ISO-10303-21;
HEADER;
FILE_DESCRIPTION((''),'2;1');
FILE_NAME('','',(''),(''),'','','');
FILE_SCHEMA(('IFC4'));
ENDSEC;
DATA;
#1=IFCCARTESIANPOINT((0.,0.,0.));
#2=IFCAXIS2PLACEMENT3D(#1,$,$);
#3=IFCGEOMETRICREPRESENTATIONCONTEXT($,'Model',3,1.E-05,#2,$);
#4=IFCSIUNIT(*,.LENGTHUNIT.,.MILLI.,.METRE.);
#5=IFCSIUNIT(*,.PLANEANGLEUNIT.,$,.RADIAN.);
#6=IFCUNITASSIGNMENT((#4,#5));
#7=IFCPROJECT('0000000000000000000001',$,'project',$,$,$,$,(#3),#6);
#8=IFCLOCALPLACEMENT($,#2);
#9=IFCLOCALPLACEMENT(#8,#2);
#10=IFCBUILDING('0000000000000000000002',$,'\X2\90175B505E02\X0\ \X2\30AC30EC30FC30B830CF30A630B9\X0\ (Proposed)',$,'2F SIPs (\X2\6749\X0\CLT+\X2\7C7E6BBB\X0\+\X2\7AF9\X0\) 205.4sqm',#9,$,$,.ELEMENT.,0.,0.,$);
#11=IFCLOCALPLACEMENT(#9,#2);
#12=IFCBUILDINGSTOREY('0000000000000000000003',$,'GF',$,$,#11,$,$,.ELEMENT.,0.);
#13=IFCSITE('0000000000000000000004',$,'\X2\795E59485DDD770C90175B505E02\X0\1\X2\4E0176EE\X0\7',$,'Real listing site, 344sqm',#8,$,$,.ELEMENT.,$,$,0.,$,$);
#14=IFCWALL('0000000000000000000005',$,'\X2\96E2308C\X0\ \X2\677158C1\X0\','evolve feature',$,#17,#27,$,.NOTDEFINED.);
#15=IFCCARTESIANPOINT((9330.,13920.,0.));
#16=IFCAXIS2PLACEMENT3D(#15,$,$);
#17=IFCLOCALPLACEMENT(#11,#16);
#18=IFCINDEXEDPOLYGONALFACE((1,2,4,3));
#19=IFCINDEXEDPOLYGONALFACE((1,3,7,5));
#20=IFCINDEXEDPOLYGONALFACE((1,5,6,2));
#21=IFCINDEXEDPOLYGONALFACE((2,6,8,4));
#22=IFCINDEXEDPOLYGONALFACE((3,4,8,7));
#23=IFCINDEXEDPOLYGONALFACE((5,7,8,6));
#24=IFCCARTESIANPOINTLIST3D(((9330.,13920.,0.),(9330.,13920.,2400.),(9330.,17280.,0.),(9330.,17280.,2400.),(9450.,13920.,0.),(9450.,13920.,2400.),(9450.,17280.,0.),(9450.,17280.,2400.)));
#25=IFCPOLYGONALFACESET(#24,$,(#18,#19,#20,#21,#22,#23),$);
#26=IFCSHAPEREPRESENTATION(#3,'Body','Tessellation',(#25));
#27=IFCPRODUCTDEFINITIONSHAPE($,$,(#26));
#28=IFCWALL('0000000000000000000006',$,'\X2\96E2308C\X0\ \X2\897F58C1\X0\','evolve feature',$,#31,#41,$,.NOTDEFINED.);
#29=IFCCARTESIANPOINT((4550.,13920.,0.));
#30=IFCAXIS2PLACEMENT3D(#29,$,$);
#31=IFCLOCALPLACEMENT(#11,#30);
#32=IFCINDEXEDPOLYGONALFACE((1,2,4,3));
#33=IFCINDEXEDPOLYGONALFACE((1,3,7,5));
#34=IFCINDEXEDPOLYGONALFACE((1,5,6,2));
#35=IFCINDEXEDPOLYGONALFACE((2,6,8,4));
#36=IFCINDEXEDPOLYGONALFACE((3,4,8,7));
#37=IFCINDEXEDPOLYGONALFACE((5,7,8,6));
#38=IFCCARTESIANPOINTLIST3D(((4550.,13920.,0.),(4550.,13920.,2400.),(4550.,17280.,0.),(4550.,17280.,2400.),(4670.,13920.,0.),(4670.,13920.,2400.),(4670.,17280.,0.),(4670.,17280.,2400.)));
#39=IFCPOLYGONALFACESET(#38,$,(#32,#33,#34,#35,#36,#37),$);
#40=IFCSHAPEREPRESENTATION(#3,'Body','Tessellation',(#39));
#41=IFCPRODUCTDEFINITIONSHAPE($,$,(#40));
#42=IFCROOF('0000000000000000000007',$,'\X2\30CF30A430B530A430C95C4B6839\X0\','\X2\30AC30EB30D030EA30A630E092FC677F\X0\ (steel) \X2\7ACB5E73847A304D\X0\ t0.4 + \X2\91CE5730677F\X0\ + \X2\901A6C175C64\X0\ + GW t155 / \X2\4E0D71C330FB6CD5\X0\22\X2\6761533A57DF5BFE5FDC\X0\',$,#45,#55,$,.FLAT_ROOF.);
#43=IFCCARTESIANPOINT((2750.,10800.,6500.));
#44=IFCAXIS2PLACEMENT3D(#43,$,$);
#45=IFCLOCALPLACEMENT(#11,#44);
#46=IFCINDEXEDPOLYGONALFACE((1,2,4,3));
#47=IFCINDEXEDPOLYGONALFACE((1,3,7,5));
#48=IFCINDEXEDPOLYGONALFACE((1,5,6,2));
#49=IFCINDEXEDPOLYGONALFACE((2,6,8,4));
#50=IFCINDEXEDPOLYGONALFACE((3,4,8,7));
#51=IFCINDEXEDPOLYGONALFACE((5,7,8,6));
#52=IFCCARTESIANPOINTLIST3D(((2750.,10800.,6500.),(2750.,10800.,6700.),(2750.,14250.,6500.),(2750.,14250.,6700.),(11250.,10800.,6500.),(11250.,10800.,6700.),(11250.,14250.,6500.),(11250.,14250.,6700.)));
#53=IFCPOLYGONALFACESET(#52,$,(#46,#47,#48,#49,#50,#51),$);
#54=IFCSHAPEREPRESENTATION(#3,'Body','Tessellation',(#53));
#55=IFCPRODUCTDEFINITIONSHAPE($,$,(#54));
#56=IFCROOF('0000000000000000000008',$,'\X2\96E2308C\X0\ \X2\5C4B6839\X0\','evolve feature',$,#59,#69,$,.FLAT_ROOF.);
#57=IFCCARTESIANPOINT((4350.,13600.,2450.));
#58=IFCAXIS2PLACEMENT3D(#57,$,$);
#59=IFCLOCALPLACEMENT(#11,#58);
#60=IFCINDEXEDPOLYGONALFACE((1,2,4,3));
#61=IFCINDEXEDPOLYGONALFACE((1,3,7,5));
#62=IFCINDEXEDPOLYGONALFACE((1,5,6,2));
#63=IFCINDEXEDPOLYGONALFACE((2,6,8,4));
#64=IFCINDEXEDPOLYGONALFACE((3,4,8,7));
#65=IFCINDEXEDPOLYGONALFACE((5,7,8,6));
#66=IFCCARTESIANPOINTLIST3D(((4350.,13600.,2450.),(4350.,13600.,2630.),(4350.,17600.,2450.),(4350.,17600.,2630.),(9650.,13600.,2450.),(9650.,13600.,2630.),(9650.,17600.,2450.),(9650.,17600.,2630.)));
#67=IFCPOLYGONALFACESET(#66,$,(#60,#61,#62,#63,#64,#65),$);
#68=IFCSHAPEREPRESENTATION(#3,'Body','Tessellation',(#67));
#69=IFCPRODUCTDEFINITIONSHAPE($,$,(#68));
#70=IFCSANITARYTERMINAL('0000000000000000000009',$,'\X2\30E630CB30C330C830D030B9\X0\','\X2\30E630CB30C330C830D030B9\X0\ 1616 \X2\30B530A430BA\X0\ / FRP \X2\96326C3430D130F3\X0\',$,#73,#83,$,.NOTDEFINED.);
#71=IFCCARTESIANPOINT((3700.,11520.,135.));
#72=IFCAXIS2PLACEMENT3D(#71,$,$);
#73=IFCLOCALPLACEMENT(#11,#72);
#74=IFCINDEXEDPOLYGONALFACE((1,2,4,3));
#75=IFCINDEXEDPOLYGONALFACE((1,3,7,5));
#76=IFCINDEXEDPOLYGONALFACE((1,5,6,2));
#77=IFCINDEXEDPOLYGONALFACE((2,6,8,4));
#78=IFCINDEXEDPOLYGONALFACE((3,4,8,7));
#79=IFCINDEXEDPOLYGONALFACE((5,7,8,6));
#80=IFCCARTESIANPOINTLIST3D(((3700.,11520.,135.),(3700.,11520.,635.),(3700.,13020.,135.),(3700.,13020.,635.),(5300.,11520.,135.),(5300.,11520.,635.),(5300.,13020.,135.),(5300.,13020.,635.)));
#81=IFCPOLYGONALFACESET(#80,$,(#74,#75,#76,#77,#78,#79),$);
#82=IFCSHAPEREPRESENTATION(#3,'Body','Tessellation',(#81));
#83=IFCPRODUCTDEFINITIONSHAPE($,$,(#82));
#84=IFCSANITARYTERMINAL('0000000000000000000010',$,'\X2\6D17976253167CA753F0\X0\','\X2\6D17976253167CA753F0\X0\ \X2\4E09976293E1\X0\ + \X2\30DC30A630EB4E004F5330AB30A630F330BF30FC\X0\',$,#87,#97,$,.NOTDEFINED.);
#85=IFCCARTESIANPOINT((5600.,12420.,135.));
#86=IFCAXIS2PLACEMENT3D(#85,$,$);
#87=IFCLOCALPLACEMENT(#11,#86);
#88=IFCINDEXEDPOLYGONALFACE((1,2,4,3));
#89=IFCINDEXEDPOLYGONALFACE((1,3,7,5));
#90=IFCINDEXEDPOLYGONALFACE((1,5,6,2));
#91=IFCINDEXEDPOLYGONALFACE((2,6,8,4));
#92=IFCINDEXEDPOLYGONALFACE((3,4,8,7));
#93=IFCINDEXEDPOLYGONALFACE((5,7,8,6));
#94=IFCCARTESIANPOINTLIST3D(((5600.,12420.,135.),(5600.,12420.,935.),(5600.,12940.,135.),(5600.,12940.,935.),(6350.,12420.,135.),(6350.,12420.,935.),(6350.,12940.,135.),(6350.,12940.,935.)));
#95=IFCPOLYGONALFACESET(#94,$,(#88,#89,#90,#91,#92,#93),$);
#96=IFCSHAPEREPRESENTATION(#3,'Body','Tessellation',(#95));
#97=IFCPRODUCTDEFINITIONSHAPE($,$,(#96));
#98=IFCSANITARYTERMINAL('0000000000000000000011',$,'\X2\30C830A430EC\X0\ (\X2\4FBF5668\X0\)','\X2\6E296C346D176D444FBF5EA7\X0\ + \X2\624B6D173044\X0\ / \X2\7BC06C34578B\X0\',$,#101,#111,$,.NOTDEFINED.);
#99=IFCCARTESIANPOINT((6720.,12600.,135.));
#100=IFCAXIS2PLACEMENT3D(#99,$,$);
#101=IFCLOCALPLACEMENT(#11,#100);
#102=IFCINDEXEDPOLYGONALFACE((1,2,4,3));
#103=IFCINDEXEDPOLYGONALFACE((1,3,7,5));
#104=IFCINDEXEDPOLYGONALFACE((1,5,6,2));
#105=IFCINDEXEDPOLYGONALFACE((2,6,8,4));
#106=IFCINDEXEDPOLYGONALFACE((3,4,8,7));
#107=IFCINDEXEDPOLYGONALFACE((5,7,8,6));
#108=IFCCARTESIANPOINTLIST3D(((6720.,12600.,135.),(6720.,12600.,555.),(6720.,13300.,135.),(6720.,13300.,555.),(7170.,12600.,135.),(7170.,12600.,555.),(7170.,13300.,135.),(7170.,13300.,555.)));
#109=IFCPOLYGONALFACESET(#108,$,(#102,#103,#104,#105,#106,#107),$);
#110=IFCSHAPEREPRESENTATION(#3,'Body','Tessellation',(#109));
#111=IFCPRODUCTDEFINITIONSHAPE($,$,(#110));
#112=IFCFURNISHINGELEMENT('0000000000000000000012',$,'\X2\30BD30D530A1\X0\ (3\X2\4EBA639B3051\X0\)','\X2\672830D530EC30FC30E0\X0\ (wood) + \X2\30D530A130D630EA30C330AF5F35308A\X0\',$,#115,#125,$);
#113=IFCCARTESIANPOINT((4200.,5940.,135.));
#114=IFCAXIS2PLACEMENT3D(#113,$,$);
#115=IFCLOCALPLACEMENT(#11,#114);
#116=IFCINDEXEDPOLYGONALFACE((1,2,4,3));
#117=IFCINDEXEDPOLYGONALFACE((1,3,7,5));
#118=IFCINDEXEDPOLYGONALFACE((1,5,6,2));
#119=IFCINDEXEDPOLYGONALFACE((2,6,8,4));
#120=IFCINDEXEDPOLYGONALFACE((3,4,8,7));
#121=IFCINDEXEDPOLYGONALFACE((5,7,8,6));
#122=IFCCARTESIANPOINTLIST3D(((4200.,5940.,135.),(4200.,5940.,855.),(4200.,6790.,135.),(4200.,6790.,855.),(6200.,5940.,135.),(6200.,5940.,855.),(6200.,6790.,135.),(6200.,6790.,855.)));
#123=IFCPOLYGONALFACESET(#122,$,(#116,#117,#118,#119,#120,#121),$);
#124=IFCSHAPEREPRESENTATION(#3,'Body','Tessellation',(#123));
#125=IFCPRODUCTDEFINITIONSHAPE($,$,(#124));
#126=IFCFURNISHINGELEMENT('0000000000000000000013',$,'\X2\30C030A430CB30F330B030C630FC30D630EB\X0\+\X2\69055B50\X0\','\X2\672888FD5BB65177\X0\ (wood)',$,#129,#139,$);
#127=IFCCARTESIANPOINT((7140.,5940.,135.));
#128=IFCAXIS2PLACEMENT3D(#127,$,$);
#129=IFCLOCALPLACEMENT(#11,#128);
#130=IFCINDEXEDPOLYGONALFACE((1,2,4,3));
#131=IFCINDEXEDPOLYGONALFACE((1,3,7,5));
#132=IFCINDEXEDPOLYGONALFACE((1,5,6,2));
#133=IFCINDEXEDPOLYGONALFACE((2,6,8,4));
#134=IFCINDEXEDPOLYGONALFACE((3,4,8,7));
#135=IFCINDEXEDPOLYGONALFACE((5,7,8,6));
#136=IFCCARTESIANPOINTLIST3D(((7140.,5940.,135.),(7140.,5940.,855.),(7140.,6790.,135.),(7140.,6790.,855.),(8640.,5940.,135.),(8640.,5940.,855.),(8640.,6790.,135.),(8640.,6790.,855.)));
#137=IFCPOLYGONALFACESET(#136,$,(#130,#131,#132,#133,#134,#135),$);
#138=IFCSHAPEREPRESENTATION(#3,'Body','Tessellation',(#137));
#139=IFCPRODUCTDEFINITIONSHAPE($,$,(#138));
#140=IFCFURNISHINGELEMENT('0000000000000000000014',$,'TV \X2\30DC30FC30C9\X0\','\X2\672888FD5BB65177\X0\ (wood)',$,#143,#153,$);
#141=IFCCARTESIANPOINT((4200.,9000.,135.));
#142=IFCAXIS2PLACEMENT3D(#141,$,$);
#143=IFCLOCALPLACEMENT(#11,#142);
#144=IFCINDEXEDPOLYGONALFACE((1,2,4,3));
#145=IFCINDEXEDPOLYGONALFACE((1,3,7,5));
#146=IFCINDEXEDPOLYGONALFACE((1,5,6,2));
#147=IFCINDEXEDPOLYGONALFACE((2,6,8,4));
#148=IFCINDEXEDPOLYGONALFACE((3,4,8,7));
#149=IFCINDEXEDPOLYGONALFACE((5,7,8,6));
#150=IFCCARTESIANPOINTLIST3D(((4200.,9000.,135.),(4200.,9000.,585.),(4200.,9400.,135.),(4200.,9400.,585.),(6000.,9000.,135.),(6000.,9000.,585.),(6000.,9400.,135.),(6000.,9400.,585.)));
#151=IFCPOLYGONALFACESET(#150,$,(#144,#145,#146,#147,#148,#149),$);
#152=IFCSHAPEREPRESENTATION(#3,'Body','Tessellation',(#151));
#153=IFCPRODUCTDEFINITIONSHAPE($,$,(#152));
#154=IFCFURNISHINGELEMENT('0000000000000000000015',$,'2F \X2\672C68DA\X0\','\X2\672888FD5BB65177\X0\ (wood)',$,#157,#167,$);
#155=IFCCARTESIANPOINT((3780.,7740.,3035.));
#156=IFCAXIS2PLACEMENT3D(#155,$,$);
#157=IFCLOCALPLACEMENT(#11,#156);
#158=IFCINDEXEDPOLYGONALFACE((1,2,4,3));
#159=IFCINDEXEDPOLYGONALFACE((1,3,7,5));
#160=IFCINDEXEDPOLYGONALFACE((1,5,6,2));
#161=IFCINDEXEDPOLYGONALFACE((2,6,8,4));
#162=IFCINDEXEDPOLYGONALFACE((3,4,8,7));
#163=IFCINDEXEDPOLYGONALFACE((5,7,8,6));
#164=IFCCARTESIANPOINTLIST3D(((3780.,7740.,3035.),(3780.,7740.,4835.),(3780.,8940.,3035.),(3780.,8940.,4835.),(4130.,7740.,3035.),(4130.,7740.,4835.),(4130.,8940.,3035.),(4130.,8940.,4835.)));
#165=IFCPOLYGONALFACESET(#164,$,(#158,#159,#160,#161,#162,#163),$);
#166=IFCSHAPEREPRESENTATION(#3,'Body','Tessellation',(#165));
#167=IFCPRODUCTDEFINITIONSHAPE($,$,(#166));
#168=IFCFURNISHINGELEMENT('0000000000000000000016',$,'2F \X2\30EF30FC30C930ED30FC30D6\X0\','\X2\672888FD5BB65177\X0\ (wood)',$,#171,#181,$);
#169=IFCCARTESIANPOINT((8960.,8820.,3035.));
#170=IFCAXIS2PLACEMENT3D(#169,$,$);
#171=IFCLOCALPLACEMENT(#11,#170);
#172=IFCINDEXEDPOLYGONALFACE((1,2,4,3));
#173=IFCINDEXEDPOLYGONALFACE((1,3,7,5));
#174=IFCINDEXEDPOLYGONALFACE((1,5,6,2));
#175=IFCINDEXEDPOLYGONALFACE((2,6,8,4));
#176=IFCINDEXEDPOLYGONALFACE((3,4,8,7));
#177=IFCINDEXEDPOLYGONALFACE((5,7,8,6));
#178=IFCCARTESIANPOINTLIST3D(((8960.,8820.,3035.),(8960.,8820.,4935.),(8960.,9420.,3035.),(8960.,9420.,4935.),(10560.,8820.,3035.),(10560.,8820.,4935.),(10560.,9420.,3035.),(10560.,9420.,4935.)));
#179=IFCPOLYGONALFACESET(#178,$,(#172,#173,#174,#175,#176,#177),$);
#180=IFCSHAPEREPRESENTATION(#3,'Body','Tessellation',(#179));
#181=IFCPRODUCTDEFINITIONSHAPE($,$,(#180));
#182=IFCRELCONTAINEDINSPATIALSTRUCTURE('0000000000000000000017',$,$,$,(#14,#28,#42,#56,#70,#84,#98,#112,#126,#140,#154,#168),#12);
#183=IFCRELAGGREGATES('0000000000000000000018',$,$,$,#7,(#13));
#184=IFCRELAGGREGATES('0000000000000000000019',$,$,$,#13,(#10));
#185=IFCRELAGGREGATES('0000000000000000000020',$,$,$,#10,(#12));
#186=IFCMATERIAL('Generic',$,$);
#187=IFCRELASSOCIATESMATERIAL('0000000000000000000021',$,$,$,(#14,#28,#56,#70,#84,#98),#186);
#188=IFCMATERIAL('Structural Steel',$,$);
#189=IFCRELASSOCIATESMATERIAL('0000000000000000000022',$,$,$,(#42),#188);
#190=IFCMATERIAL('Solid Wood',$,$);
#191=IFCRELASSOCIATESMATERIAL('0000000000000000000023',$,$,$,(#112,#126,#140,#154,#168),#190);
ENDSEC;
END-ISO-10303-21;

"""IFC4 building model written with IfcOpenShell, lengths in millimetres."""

from ifc_helpers import new_model, si_unit, frame, frame_2d, origin, place, context, project, spatial, rectangle, extrude, material, element, save


model = new_model("IFC4")

# Units and contexts
model_context = context("Model", 3, precision=1e-05, world=origin())
ifc_project = project(units=[si_unit("LENGTHUNIT", "METRE", prefix="MILLI"), si_unit("PLANEANGLEUNIT", "RADIAN")], contexts=[model_context])

# Site, building, storey
site_placement = place(None, origin())
site = spatial("IfcSite", under=ifc_project, at=site_placement, Name="神奈川県逗子市1丁目7", ObjectType="Real listing site, 344sqm", CompositionType="ELEMENT", RefElevation=0.0)
building_placement = place(site_placement, origin())
building = spatial("IfcBuilding", under=site, at=building_placement, Name="逗子市 ガレージハウス (Proposed)", ObjectType="2F SIPs (杉CLT+籾殻+竹) 205.4sqm", CompositionType="ELEMENT", ElevationOfRefHeight=0.0, ElevationOfTerrain=0.0)
storey_placement = place(building_placement, origin())
storey = spatial("IfcBuildingStorey", under=building, at=storey_placement, Name="GF", CompositionType="ELEMENT", Elevation=0.0)

# Shared definitions
ifc_material_1 = material(Name="Generic")

# Shared definitions
ifc_material_2 = material(Name="Solid Wood")

# Walls
wall_1_placement = place(storey_placement, frame((9330.0, 13920.0, 0.0)))
element("IfcWall", 1, at=wall_1_placement, inside=storey, material=ifc_material_1, Name="離れ 東壁", Description="evolve feature", PredefinedType="NOTDEFINED", context=model_context, shape_type="SweptSolid", body=[
    extrude(rectangle(XDim=120.0, YDim=3360.0, at=frame_2d((60.0, 1680.0))), frame((9330.0, 13920.0, 0.0)), (0.0, 0.0, 1.0), 2400.0),
])
wall_2_placement = place(storey_placement, frame((4550.0, 13920.0, 0.0)))
element("IfcWall", 2, at=wall_2_placement, inside=storey, material=ifc_material_1, Name="離れ 西壁", Description="evolve feature", PredefinedType="NOTDEFINED", context=model_context, shape_type="SweptSolid", body=[
    extrude(rectangle(XDim=120.0, YDim=3360.0, at=frame_2d((60.0, 1680.0))), frame((4550.0, 13920.0, 0.0)), (0.0, 0.0, 1.0), 2400.0),
])

# Roofs
ifc_material_3 = material(Name="Structural Steel")
roof_1_placement = place(storey_placement, frame((2750.0, 10800.0, 6500.0)))
element("IfcRoof", 3, at=roof_1_placement, inside=storey, material=ifc_material_3, Name="ハイサイド屋根", Description="ガルバリウム鋼板 (steel) 立平葺き t0.4 + 野地板 + 通気層 + GW t155 / 不燃・法22条区域対応", PredefinedType="FLAT_ROOF", context=model_context, shape_type="SweptSolid", body=[
    extrude(rectangle(XDim=8500.0, YDim=3450.0, at=frame_2d((4250.0, 1725.0))), frame((2750.0, 10800.0, 6500.0)), (0.0, 0.0, 1.0), 200.0),
])
roof_2_placement = place(storey_placement, frame((4350.0, 13600.0, 2450.0)))
element("IfcRoof", 4, at=roof_2_placement, inside=storey, material=ifc_material_1, Name="離れ 屋根", Description="evolve feature", PredefinedType="FLAT_ROOF", context=model_context, shape_type="SweptSolid", body=[
    extrude(rectangle(XDim=5300.0, YDim=4000.0, at=frame_2d((2650.0, 2000.0))), frame((4350.0, 13600.0, 2450.0)), (0.0, 0.0, 1.0), 180.0),
])

# Sanitary terminals
sanitary_terminal_1_placement = place(storey_placement, frame((3700.0, 11520.0, 135.0)))
element("IfcSanitaryTerminal", 5, at=sanitary_terminal_1_placement, inside=storey, material=ifc_material_1, Name="ユニットバス", Description="ユニットバス 1616 サイズ / FRP 防水パン", PredefinedType="NOTDEFINED", context=model_context, shape_type="SweptSolid", body=[
    extrude(rectangle(XDim=1600.0, YDim=1500.0, at=frame_2d((800.0, 750.0))), frame((3700.0, 11520.0, 135.0)), (0.0, 0.0, 1.0), 500.0),
])
sanitary_terminal_2_placement = place(storey_placement, frame((5600.0, 12420.0, 135.0)))
element("IfcSanitaryTerminal", 6, at=sanitary_terminal_2_placement, inside=storey, material=ifc_material_1, Name="洗面化粧台", Description="洗面化粧台 三面鏡 + ボウル一体カウンター", PredefinedType="NOTDEFINED", context=model_context, shape_type="SweptSolid", body=[
    extrude(rectangle(XDim=750.0, YDim=520.0, at=frame_2d((375.0, 260.0))), frame((5600.0, 12420.0, 135.0)), (0.0, 0.0, 1.0), 800.0),
])
sanitary_terminal_3_placement = place(storey_placement, frame((6720.0, 12600.0, 135.0)))
element("IfcSanitaryTerminal", 7, at=sanitary_terminal_3_placement, inside=storey, material=ifc_material_1, Name="トイレ (便器)", Description="温水洗浄便座 + 手洗い / 節水型", PredefinedType="NOTDEFINED", context=model_context, shape_type="SweptSolid", body=[
    extrude(rectangle(XDim=450.0, YDim=700.0, at=frame_2d((225.0, 350.0))), frame((6720.0, 12600.0, 135.0)), (0.0, 0.0, 1.0), 420.0),
])

# Furnishing elements
furnishing_1_placement = place(storey_placement, frame((4200.0, 5940.0, 135.0)))
element("IfcFurnishingElement", 8, at=furnishing_1_placement, inside=storey, material=ifc_material_2, Name="ソファ (3人掛け)", Description="木フレーム (wood) + ファブリック張り", context=model_context, shape_type="SweptSolid", body=[
    extrude(rectangle(XDim=2000.0, YDim=850.0, at=frame_2d((1000.0, 425.0))), frame((4200.0, 5940.0, 135.0)), (0.0, 0.0, 1.0), 720.0),
])
furnishing_2_placement = place(storey_placement, frame((7140.0, 5940.0, 135.0)))
element("IfcFurnishingElement", 9, at=furnishing_2_placement, inside=storey, material=ifc_material_2, Name="ダイニングテーブル+椅子", Description="木製家具 (wood)", context=model_context, shape_type="SweptSolid", body=[
    extrude(rectangle(XDim=1500.0, YDim=850.0, at=frame_2d((750.0, 425.0))), frame((7140.0, 5940.0, 135.0)), (0.0, 0.0, 1.0), 720.0),
])
furnishing_3_placement = place(storey_placement, frame((4200.0, 9000.0, 135.0)))
element("IfcFurnishingElement", 10, at=furnishing_3_placement, inside=storey, material=ifc_material_2, Name="TV ボード", Description="木製家具 (wood)", context=model_context, shape_type="SweptSolid", body=[
    extrude(rectangle(XDim=1800.0, YDim=400.0, at=frame_2d((900.0, 200.0))), frame((4200.0, 9000.0, 135.0)), (0.0, 0.0, 1.0), 450.0),
])
furnishing_4_placement = place(storey_placement, frame((3780.0, 7740.0, 3035.0)))
element("IfcFurnishingElement", 11, at=furnishing_4_placement, inside=storey, material=ifc_material_2, Name="2F 本棚", Description="木製家具 (wood)", context=model_context, shape_type="SweptSolid", body=[
    extrude(rectangle(XDim=350.0, YDim=1200.0, at=frame_2d((175.0, 600.0))), frame((3780.0, 7740.0, 3035.0)), (0.0, 0.0, 1.0), 1800.0),
])
furnishing_5_placement = place(storey_placement, frame((8960.0, 8820.0, 3035.0)))
element("IfcFurnishingElement", 12, at=furnishing_5_placement, inside=storey, material=ifc_material_2, Name="2F ワードローブ", Description="木製家具 (wood)", context=model_context, shape_type="SweptSolid", body=[
    extrude(rectangle(XDim=1600.0, YDim=600.0, at=frame_2d((800.0, 300.0))), frame((8960.0, 8820.0, 3035.0)), (0.0, 0.0, 1.0), 1900.0),
])

save(model, "model.ifc")
